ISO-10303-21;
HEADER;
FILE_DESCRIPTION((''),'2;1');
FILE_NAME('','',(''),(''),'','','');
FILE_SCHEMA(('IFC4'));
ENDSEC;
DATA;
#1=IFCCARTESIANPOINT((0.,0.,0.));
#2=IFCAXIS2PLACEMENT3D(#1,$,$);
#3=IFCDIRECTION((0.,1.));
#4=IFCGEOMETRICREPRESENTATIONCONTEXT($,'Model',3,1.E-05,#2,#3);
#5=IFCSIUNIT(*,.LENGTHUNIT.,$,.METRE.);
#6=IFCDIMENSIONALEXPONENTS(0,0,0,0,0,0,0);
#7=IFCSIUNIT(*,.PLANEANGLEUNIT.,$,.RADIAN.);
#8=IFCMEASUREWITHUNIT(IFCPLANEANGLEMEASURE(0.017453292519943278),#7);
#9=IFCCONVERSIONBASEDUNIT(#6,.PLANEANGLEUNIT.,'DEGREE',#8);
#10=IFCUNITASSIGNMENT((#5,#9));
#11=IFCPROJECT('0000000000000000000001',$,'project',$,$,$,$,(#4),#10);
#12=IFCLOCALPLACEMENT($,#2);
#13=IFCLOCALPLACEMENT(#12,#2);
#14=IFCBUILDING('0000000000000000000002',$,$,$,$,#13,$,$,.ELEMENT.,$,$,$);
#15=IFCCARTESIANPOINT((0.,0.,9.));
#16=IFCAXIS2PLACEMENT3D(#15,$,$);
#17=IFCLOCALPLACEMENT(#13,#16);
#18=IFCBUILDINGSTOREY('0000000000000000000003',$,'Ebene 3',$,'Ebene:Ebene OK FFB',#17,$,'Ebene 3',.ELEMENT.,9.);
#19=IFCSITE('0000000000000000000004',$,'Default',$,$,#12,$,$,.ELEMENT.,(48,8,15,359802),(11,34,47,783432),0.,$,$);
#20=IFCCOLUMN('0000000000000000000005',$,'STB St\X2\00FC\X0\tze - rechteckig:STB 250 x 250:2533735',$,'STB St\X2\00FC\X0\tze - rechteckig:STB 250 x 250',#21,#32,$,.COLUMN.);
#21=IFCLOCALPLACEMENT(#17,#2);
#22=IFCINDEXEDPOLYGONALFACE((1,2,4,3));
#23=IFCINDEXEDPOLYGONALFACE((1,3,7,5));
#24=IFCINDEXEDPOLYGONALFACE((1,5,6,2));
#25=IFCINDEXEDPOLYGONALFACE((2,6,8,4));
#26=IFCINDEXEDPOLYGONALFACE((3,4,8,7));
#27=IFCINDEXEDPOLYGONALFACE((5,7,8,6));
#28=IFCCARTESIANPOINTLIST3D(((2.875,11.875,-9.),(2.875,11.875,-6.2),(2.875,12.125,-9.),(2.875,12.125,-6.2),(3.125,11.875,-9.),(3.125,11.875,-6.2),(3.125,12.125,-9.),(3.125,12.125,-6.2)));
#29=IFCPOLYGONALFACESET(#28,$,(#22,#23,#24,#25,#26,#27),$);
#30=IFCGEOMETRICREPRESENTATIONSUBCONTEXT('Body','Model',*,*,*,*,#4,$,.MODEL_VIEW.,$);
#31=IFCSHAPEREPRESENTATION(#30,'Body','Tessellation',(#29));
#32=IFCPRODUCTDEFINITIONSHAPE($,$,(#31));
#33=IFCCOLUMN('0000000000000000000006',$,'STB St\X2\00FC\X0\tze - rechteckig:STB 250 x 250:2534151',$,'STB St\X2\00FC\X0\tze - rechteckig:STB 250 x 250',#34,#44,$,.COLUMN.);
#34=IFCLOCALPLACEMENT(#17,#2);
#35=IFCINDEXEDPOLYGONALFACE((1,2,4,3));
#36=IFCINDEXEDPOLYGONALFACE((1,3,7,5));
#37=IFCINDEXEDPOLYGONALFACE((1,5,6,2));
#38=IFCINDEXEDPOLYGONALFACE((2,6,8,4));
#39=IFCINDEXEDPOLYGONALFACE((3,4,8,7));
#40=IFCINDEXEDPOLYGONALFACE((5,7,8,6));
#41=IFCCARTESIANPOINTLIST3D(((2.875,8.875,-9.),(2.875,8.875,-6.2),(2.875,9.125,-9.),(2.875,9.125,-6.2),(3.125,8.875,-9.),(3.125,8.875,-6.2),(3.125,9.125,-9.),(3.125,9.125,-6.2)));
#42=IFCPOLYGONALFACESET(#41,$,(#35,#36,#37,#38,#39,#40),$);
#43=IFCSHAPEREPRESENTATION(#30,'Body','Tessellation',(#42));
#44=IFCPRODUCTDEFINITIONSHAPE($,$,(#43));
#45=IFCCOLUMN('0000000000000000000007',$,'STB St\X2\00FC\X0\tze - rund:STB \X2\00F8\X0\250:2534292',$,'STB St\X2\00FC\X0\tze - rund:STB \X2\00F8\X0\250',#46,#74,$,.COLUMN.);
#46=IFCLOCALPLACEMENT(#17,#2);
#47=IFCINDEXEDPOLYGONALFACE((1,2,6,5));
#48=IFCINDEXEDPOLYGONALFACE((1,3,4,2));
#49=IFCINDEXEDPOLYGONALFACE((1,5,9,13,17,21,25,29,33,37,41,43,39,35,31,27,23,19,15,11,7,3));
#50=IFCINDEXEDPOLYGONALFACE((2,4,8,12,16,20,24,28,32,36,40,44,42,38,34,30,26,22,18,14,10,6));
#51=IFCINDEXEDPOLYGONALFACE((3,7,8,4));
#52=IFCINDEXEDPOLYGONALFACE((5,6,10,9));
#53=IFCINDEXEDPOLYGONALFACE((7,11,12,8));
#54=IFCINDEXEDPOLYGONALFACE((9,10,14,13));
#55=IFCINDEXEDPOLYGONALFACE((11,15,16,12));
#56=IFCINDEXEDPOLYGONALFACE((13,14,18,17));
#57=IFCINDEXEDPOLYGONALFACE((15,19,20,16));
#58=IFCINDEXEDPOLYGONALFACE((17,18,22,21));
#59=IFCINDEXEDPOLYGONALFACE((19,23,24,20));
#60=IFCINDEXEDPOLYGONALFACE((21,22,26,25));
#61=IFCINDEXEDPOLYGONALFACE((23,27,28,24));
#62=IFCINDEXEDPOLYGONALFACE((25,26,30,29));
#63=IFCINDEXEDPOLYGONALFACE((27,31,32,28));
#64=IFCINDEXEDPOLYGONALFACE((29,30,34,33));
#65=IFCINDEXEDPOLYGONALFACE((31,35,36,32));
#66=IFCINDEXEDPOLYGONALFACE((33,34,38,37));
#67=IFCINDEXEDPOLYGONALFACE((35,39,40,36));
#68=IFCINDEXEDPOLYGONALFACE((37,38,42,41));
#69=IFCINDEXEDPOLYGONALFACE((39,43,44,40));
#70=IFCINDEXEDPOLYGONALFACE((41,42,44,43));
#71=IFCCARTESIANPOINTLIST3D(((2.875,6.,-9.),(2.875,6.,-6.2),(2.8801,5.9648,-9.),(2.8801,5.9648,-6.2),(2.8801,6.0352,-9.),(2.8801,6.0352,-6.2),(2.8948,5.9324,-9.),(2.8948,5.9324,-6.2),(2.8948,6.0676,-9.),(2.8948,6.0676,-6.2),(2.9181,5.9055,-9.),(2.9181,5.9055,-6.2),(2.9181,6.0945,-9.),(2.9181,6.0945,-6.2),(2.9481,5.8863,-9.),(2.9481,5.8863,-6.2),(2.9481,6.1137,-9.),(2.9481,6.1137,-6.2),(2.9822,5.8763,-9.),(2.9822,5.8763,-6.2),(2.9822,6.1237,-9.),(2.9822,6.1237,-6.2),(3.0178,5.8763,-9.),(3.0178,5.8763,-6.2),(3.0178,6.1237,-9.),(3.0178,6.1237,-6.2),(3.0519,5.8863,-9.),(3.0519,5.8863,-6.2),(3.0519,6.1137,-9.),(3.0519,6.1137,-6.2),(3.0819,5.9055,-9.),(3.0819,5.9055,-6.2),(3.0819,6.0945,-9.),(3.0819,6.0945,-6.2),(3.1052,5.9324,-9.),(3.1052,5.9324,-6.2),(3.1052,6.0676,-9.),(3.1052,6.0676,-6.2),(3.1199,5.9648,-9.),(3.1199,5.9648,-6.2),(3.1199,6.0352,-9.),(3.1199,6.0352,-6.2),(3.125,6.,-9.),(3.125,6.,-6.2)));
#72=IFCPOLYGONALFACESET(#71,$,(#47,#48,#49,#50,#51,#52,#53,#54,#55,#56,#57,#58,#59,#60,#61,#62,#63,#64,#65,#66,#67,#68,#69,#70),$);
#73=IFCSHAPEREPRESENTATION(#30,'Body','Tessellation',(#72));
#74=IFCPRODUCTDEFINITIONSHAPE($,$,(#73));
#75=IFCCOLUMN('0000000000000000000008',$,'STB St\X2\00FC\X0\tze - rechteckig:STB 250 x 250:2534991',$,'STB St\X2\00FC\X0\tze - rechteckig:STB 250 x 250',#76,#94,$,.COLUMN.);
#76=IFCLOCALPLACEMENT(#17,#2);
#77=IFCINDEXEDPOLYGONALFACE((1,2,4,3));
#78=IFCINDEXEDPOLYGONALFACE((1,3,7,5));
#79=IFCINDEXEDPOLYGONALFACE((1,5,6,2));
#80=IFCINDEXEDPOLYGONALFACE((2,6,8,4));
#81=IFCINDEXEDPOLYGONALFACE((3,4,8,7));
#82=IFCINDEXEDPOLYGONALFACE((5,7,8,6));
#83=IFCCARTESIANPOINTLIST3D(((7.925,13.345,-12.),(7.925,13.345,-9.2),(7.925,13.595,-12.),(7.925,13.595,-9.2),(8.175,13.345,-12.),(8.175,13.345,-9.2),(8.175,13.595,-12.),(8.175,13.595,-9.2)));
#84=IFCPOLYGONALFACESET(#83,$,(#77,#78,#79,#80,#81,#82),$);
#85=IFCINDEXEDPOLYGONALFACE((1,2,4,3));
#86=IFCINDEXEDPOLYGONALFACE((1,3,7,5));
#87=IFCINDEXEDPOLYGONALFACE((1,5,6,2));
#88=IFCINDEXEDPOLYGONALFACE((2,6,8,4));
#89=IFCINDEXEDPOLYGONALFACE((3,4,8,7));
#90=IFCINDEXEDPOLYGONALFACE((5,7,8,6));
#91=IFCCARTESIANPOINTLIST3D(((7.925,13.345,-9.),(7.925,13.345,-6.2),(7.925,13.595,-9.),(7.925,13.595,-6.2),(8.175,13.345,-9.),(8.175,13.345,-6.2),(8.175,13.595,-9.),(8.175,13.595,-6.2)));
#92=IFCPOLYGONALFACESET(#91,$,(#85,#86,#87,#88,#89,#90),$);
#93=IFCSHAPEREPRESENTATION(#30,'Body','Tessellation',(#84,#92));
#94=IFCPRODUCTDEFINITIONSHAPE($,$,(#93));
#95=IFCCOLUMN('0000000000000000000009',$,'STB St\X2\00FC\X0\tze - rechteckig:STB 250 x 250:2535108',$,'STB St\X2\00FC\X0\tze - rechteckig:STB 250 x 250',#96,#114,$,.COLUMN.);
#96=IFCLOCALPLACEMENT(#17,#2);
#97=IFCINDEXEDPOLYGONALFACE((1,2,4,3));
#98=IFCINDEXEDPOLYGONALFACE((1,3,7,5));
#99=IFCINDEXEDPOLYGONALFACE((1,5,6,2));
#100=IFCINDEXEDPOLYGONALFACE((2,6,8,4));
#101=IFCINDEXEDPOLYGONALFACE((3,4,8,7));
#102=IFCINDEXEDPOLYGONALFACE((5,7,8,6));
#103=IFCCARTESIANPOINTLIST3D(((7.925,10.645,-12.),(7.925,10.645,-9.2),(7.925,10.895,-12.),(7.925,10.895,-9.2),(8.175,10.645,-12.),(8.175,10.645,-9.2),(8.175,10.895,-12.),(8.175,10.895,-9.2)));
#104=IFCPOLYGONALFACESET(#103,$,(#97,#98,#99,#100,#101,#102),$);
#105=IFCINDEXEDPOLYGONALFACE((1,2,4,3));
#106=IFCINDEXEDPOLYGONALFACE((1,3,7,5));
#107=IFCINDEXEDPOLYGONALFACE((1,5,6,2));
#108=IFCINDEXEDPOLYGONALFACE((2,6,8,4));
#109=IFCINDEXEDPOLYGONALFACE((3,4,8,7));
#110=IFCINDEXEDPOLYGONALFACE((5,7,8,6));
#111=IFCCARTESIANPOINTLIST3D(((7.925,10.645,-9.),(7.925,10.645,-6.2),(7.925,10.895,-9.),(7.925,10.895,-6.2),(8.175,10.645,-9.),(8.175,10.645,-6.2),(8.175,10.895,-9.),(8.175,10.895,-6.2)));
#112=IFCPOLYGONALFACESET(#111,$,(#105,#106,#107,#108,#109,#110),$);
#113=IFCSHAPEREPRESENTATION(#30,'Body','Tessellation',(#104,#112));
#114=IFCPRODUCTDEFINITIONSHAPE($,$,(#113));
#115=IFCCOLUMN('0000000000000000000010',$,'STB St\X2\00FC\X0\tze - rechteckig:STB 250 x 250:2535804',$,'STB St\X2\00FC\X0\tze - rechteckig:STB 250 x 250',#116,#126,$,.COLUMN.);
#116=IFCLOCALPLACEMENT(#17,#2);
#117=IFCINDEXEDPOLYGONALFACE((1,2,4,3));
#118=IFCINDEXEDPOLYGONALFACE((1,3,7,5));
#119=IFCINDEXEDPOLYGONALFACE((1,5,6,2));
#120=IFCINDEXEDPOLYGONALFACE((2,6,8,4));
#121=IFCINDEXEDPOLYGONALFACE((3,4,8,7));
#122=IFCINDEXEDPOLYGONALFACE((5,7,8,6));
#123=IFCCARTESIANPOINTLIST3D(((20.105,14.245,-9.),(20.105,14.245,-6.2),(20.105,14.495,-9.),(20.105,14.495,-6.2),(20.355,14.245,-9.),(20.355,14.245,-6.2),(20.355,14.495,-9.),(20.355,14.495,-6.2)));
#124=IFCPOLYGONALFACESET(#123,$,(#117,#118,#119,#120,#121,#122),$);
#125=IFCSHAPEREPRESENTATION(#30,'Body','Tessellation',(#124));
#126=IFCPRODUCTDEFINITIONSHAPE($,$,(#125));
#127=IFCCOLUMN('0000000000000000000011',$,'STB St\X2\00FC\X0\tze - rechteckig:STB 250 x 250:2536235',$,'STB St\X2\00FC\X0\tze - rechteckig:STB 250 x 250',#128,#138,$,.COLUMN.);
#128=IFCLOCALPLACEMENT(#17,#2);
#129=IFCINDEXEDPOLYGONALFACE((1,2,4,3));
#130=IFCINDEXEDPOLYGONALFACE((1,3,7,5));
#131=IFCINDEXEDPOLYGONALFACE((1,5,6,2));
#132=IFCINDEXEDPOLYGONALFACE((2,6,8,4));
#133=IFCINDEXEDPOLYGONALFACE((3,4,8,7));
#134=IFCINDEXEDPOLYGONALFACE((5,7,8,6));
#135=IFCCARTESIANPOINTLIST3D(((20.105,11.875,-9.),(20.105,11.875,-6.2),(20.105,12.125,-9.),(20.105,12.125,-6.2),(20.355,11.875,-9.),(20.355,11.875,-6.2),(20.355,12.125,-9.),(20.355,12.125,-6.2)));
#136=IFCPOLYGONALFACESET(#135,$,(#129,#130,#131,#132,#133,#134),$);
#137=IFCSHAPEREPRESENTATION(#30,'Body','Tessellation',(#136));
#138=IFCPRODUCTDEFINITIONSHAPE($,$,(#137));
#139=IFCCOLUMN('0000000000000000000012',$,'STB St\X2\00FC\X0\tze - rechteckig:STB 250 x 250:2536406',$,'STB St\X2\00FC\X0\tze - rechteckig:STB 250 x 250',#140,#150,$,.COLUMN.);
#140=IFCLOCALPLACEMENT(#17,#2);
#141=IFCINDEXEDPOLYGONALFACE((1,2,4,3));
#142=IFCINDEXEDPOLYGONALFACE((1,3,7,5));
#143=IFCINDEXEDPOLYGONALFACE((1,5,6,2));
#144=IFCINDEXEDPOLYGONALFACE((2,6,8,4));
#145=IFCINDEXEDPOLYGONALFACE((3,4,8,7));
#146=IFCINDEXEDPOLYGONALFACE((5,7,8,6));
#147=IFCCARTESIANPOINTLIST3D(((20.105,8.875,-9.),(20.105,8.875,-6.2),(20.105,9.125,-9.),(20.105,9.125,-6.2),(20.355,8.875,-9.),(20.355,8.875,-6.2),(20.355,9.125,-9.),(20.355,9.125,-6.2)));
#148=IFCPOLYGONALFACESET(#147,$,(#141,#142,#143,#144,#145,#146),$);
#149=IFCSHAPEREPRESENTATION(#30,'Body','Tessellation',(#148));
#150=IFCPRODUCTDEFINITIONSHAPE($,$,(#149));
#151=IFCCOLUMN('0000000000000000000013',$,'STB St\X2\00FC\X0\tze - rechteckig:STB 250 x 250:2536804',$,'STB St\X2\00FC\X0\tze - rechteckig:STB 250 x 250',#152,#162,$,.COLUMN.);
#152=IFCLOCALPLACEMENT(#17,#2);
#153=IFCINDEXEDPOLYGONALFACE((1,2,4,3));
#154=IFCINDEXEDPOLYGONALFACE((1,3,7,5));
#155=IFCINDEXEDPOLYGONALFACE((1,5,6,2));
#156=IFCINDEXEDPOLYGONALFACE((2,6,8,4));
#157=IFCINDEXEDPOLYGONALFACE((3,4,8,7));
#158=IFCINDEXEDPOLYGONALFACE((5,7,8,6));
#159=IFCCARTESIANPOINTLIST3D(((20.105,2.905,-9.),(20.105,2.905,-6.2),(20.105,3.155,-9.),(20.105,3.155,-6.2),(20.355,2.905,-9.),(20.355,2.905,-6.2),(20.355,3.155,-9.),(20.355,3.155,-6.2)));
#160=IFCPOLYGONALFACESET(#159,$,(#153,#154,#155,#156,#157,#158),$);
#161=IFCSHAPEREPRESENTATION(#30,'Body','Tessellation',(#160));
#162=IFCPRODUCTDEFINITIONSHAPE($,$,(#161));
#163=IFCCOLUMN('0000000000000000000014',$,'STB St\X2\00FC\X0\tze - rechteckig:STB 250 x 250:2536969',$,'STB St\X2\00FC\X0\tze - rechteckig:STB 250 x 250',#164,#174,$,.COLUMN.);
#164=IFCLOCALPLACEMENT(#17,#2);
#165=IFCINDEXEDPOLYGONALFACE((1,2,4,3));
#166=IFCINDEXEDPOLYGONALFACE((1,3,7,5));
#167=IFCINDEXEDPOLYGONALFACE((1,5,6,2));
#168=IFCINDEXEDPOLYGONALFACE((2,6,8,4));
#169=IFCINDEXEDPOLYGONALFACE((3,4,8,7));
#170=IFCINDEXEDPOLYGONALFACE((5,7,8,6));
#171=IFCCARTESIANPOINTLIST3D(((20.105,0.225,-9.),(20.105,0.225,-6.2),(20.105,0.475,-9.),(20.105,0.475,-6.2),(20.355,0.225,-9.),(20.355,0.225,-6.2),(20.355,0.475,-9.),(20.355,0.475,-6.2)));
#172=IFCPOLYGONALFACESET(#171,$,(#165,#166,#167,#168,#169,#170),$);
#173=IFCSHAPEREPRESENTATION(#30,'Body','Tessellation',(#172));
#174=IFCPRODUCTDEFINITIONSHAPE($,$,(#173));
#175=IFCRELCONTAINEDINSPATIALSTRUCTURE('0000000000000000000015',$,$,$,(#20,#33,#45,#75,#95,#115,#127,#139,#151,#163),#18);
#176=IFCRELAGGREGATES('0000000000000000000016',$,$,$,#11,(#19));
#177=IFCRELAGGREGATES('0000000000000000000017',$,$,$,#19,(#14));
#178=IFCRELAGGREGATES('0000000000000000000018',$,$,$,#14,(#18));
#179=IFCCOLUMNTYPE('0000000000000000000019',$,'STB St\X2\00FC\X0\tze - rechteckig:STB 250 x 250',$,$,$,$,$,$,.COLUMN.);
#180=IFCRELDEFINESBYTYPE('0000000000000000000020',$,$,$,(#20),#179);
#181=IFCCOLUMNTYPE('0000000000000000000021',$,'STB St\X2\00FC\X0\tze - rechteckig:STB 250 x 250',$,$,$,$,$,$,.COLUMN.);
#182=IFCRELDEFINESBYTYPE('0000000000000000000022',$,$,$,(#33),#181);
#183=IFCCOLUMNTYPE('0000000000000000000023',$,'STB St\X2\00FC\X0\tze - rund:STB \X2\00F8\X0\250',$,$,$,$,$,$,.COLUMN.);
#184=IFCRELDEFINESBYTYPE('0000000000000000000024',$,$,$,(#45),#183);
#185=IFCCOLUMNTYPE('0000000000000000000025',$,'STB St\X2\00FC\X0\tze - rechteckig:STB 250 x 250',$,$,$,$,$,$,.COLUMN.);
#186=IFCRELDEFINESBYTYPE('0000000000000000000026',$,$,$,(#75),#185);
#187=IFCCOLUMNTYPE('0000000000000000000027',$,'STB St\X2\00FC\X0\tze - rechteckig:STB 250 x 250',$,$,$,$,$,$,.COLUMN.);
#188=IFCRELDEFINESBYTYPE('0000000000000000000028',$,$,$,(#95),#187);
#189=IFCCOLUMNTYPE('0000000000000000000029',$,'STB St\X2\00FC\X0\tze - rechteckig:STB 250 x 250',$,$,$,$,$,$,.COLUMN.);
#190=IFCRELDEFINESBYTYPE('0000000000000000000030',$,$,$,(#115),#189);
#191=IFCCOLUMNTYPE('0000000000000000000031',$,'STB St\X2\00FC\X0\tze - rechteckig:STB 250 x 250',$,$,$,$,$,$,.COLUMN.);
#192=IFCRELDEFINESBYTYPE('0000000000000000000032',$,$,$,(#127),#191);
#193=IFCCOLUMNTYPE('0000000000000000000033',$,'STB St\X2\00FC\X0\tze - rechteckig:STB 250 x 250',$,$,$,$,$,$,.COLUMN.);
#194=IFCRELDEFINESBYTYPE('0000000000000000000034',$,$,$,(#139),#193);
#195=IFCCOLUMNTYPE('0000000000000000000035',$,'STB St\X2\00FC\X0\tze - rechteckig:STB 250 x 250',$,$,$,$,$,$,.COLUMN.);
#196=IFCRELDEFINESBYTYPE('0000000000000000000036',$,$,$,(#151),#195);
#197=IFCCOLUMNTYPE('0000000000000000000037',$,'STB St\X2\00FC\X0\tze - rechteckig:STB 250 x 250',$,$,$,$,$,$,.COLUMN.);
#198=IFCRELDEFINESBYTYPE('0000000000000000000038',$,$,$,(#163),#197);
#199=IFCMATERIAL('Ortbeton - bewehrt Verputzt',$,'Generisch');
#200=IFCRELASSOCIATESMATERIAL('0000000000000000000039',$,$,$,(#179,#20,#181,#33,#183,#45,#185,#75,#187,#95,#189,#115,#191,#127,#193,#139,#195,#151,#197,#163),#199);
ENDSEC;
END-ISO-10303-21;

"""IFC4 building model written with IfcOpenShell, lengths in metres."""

from ifc_helpers import new_model, entity, si_unit, converted_unit, direction, frame, origin, place, context, subcontext, project, spatial, arc, indexed_curve, outline, extrude, source, transform, mapped, material, type_object, type_shapes, element, save


model = new_model("IFC4")

# Units and contexts
model_context = context("Model", 3, precision=1e-05, world=origin(), true_north=direction((0.0, 1.0)))
body_context = subcontext(model_context, "Body", "Model", "MODEL_VIEW")
ifc_project = project(units=[si_unit("LENGTHUNIT", "METRE"), converted_unit("PLANEANGLEUNIT", "DEGREE", entity("IfcPlaneAngleMeasure", 0.017453292519943278), si_unit("PLANEANGLEUNIT", "RADIAN"), dimensions=[0, 0, 0, 0, 0, 0, 0])], contexts=[model_context])

# Site, building, storey
site_placement = place(None, origin())
site = spatial("IfcSite", under=ifc_project, at=site_placement, Name="Default", CompositionType="ELEMENT", RefLatitude=(48, 8, 15, 359802), RefLongitude=(11, 34, 47, 783432), RefElevation=0.0)
building_placement = place(site_placement, origin())
building = spatial("IfcBuilding", under=site, at=building_placement, CompositionType="ELEMENT")
storey_placement = place(building_placement, frame((0.0, 0.0, 9.0)))
storey = spatial("IfcBuildingStorey", under=building, at=storey_placement, Name="Ebene 3", ObjectType="Ebene:Ebene OK FFB", LongName="Ebene 3", CompositionType="ELEMENT", Elevation=9.0)

# Columns
ifc_material_1 = material(Name="Ortbeton - bewehrt Verputzt", Category="Generisch")
column_type_1 = type_object("IfcColumnType", Name="STB Stütze - rechteckig:STB 250 x 250", PredefinedType="COLUMN", material=ifc_material_1)
shared_shape_1 = source(origin(), body_context, "Body", "SweptSolid", [
    extrude(outline(indexed_curve([(-0.125, -0.125), (0.125, -0.125), (0.125, 0.125), (-0.125, 0.125), (-0.125, -0.125)], self_intersect=False)), frame((3.0, 12.0, 0.0), z_axis=(0.0, 0.0, 1.0), x_axis=(-1.0, 0.0, 0.0)), (0.0, 0.0, 1.0), 2.8),
])
type_shapes(column_type_1, [shared_shape_1])
column_1_placement = place(storey_placement, frame((0.0, 0.0, -9.0)))
element("IfcColumn", 1, at=column_1_placement, inside=storey, type_object=column_type_1, material=ifc_material_1, Name="STB Stütze - rechteckig:STB 250 x 250:2533735", ObjectType="STB Stütze - rechteckig:STB 250 x 250", PredefinedType="COLUMN", context=body_context, shape_type="MappedRepresentation", body=[
    mapped(shared_shape_1, transform((0.0, 0.0, 0.0), scale=1.0)),
])
column_type_2 = type_object("IfcColumnType", Name="STB Stütze - rechteckig:STB 250 x 250", PredefinedType="COLUMN", material=ifc_material_1)
shared_shape_2 = source(origin(), body_context, "Body", "SweptSolid", [
    extrude(outline(indexed_curve([(-0.125, -0.125), (0.125, -0.125), (0.125, 0.125), (-0.125, 0.125), (-0.125, -0.125)], self_intersect=False)), frame((3.0, 9.0, 0.0), z_axis=(0.0, 0.0, 1.0), x_axis=(-1.0, 0.0, 0.0)), (0.0, 0.0, 1.0), 2.8),
])
type_shapes(column_type_2, [shared_shape_2])
column_2_placement = place(storey_placement, frame((0.0, 0.0, -9.0)))
element("IfcColumn", 2, at=column_2_placement, inside=storey, type_object=column_type_2, material=ifc_material_1, Name="STB Stütze - rechteckig:STB 250 x 250:2534151", ObjectType="STB Stütze - rechteckig:STB 250 x 250", PredefinedType="COLUMN", context=body_context, shape_type="MappedRepresentation", body=[
    mapped(shared_shape_2, transform((0.0, 0.0, 0.0), scale=1.0)),
])
column_type_3 = type_object("IfcColumnType", Name="STB Stütze - rund:STB ø250", PredefinedType="COLUMN", material=ifc_material_1)
shared_shape_3 = source(origin(), body_context, "Body", "SweptSolid", [
    extrude(outline(indexed_curve([(0.125, 0.0), (0.0, 0.125), (-0.125, 0.0), (0.0, -0.125)], segments=[arc(1, 2, 3), arc(3, 4, 1)], self_intersect=False)), frame((3.0, 6.0, 0.0)), (0.0, 0.0, 1.0), 2.8),
])
type_shapes(column_type_3, [shared_shape_3])
column_3_placement = place(storey_placement, frame((0.0, 0.0, -9.0)))
element("IfcColumn", 3, at=column_3_placement, inside=storey, type_object=column_type_3, material=ifc_material_1, Name="STB Stütze - rund:STB ø250:2534292", ObjectType="STB Stütze - rund:STB ø250", PredefinedType="COLUMN", context=body_context, shape_type="MappedRepresentation", body=[
    mapped(shared_shape_3, transform((0.0, 0.0, 0.0), scale=1.0)),
])
column_type_4 = type_object("IfcColumnType", Name="STB Stütze - rechteckig:STB 250 x 250", PredefinedType="COLUMN", material=ifc_material_1)
shared_shape_4 = source(origin(), body_context, "Body", "SweptSolid", [
    extrude(outline(indexed_curve([(-0.125, -0.125), (0.125, -0.125), (0.125, 0.125), (-0.125, 0.125), (-0.125, -0.125)], self_intersect=False)), frame((8.05, 13.47, -3.0), z_axis=(0.0, 0.0, 1.0), x_axis=(-1.0, 0.0, 0.0)), (0.0, 0.0, 1.0), 2.8),
    extrude(outline(indexed_curve([(-0.125, -0.125), (0.125, -0.125), (0.125, 0.125), (-0.125, 0.125), (-0.125, -0.125)], self_intersect=False)), frame((8.05, 13.47, 0.0), z_axis=(0.0, 0.0, 1.0), x_axis=(0.0, -1.0, 0.0)), (0.0, 0.0, 1.0), 2.8),
])
type_shapes(column_type_4, [shared_shape_4])
column_4_placement = place(storey_placement, frame((0.0, 0.0, -9.0)))
element("IfcColumn", 4, at=column_4_placement, inside=storey, type_object=column_type_4, material=ifc_material_1, Name="STB Stütze - rechteckig:STB 250 x 250:2534991", ObjectType="STB Stütze - rechteckig:STB 250 x 250", PredefinedType="COLUMN", context=body_context, shape_type="MappedRepresentation", body=[
    mapped(shared_shape_4, transform((0.0, 0.0, 0.0), scale=1.0)),
])
column_type_5 = type_object("IfcColumnType", Name="STB Stütze - rechteckig:STB 250 x 250", PredefinedType="COLUMN", material=ifc_material_1)
shared_shape_5 = source(origin(), body_context, "Body", "SweptSolid", [
    extrude(outline(indexed_curve([(-0.125, -0.125), (0.125, -0.125), (0.125, 0.125), (-0.125, 0.125), (-0.125, -0.125)], self_intersect=False)), frame((8.05, 10.77, -3.0), z_axis=(0.0, 0.0, 1.0), x_axis=(-1.0, 0.0, 0.0)), (0.0, 0.0, 1.0), 2.8),
    extrude(outline(indexed_curve([(-0.125, -0.125), (0.125, -0.125), (0.125, 0.125), (-0.125, 0.125), (-0.125, -0.125)], self_intersect=False)), frame((8.05, 10.77, 0.0), z_axis=(0.0, 0.0, 1.0), x_axis=(0.0, -1.0, 0.0)), (0.0, 0.0, 1.0), 2.8),
])
type_shapes(column_type_5, [shared_shape_5])
column_5_placement = place(storey_placement, frame((0.0, 0.0, -9.0)))
element("IfcColumn", 5, at=column_5_placement, inside=storey, type_object=column_type_5, material=ifc_material_1, Name="STB Stütze - rechteckig:STB 250 x 250:2535108", ObjectType="STB Stütze - rechteckig:STB 250 x 250", PredefinedType="COLUMN", context=body_context, shape_type="MappedRepresentation", body=[
    mapped(shared_shape_5, transform((0.0, 0.0, 0.0), scale=1.0)),
])
column_type_6 = type_object("IfcColumnType", Name="STB Stütze - rechteckig:STB 250 x 250", PredefinedType="COLUMN", material=ifc_material_1)
shared_shape_6 = source(origin(), body_context, "Body", "SweptSolid", [
    extrude(outline(indexed_curve([(-0.125, -0.125), (0.125, -0.125), (0.125, 0.125), (-0.125, 0.125), (-0.125, -0.125)], self_intersect=False)), frame((20.23, 14.37, 0.0), z_axis=(0.0, 0.0, 1.0), x_axis=(-1.0, 0.0, 0.0)), (0.0, 0.0, 1.0), 2.8),
])
type_shapes(column_type_6, [shared_shape_6])
column_6_placement = place(storey_placement, frame((0.0, 0.0, -9.0)))
element("IfcColumn", 6, at=column_6_placement, inside=storey, type_object=column_type_6, material=ifc_material_1, Name="STB Stütze - rechteckig:STB 250 x 250:2535804", ObjectType="STB Stütze - rechteckig:STB 250 x 250", PredefinedType="COLUMN", context=body_context, shape_type="MappedRepresentation", body=[
    mapped(shared_shape_6, transform((0.0, 0.0, 0.0), scale=1.0)),
])
column_type_7 = type_object("IfcColumnType", Name="STB Stütze - rechteckig:STB 250 x 250", PredefinedType="COLUMN", material=ifc_material_1)
shared_shape_7 = source(origin(), body_context, "Body", "SweptSolid", [
    extrude(outline(indexed_curve([(-0.125, -0.125), (0.125, -0.125), (0.125, 0.125), (-0.125, 0.125), (-0.125, -0.125)], self_intersect=False)), frame((20.23, 12.0, 0.0), z_axis=(0.0, 0.0, 1.0), x_axis=(-1.0, 0.0, 0.0)), (0.0, 0.0, 1.0), 2.8),
])
type_shapes(column_type_7, [shared_shape_7])
column_7_placement = place(storey_placement, frame((0.0, 0.0, -9.0)))
element("IfcColumn", 7, at=column_7_placement, inside=storey, type_object=column_type_7, material=ifc_material_1, Name="STB Stütze - rechteckig:STB 250 x 250:2536235", ObjectType="STB Stütze - rechteckig:STB 250 x 250", PredefinedType="COLUMN", context=body_context, shape_type="MappedRepresentation", body=[
    mapped(shared_shape_7, transform((0.0, 0.0, 0.0), scale=1.0)),
])
column_type_8 = type_object("IfcColumnType", Name="STB Stütze - rechteckig:STB 250 x 250", PredefinedType="COLUMN", material=ifc_material_1)
shared_shape_8 = source(origin(), body_context, "Body", "SweptSolid", [
    extrude(outline(indexed_curve([(-0.125, -0.125), (0.125, -0.125), (0.125, 0.125), (-0.125, 0.125), (-0.125, -0.125)], self_intersect=False)), frame((20.23, 9.0, 0.0), z_axis=(0.0, 0.0, 1.0), x_axis=(-1.0, 0.0, 0.0)), (0.0, 0.0, 1.0), 2.8),
])
type_shapes(column_type_8, [shared_shape_8])
column_8_placement = place(storey_placement, frame((0.0, 0.0, -9.0)))
element("IfcColumn", 8, at=column_8_placement, inside=storey, type_object=column_type_8, material=ifc_material_1, Name="STB Stütze - rechteckig:STB 250 x 250:2536406", ObjectType="STB Stütze - rechteckig:STB 250 x 250", PredefinedType="COLUMN", context=body_context, shape_type="MappedRepresentation", body=[
    mapped(shared_shape_8, transform((0.0, 0.0, 0.0), scale=1.0)),
])
column_type_9 = type_object("IfcColumnType", Name="STB Stütze - rechteckig:STB 250 x 250", PredefinedType="COLUMN", material=ifc_material_1)
shared_shape_9 = source(origin(), body_context, "Body", "SweptSolid", [
    extrude(outline(indexed_curve([(-0.125, -0.125), (0.125, -0.125), (0.125, 0.125), (-0.125, 0.125), (-0.125, -0.125)], self_intersect=False)), frame((20.23, 3.03, 0.0), z_axis=(0.0, 0.0, 1.0), x_axis=(-1.0, 0.0, 0.0)), (0.0, 0.0, 1.0), 2.8),
])
type_shapes(column_type_9, [shared_shape_9])
column_9_placement = place(storey_placement, frame((0.0, 0.0, -9.0)))
element("IfcColumn", 9, at=column_9_placement, inside=storey, type_object=column_type_9, material=ifc_material_1, Name="STB Stütze - rechteckig:STB 250 x 250:2536804", ObjectType="STB Stütze - rechteckig:STB 250 x 250", PredefinedType="COLUMN", context=body_context, shape_type="MappedRepresentation", body=[
    mapped(shared_shape_9, transform((0.0, 0.0, 0.0), scale=1.0)),
])
column_type_10 = type_object("IfcColumnType", Name="STB Stütze - rechteckig:STB 250 x 250", PredefinedType="COLUMN", material=ifc_material_1)
shared_shape_10 = source(origin(), body_context, "Body", "SweptSolid", [
    extrude(outline(indexed_curve([(-0.125, -0.125), (0.125, -0.125), (0.125, 0.125), (-0.125, 0.125), (-0.125, -0.125)], self_intersect=False)), frame((20.23, 0.35, 0.0), z_axis=(0.0, 0.0, 1.0), x_axis=(-1.0, 0.0, 0.0)), (0.0, 0.0, 1.0), 2.8),
])
type_shapes(column_type_10, [shared_shape_10])
column_10_placement = place(storey_placement, frame((0.0, 0.0, -9.0)))
element("IfcColumn", 10, at=column_10_placement, inside=storey, type_object=column_type_10, material=ifc_material_1, Name="STB Stütze - rechteckig:STB 250 x 250:2536969", ObjectType="STB Stütze - rechteckig:STB 250 x 250", PredefinedType="COLUMN", context=body_context, shape_type="MappedRepresentation", body=[
    mapped(shared_shape_10, transform((0.0, 0.0, 0.0), scale=1.0)),
])

save(model, "model.ifc")
